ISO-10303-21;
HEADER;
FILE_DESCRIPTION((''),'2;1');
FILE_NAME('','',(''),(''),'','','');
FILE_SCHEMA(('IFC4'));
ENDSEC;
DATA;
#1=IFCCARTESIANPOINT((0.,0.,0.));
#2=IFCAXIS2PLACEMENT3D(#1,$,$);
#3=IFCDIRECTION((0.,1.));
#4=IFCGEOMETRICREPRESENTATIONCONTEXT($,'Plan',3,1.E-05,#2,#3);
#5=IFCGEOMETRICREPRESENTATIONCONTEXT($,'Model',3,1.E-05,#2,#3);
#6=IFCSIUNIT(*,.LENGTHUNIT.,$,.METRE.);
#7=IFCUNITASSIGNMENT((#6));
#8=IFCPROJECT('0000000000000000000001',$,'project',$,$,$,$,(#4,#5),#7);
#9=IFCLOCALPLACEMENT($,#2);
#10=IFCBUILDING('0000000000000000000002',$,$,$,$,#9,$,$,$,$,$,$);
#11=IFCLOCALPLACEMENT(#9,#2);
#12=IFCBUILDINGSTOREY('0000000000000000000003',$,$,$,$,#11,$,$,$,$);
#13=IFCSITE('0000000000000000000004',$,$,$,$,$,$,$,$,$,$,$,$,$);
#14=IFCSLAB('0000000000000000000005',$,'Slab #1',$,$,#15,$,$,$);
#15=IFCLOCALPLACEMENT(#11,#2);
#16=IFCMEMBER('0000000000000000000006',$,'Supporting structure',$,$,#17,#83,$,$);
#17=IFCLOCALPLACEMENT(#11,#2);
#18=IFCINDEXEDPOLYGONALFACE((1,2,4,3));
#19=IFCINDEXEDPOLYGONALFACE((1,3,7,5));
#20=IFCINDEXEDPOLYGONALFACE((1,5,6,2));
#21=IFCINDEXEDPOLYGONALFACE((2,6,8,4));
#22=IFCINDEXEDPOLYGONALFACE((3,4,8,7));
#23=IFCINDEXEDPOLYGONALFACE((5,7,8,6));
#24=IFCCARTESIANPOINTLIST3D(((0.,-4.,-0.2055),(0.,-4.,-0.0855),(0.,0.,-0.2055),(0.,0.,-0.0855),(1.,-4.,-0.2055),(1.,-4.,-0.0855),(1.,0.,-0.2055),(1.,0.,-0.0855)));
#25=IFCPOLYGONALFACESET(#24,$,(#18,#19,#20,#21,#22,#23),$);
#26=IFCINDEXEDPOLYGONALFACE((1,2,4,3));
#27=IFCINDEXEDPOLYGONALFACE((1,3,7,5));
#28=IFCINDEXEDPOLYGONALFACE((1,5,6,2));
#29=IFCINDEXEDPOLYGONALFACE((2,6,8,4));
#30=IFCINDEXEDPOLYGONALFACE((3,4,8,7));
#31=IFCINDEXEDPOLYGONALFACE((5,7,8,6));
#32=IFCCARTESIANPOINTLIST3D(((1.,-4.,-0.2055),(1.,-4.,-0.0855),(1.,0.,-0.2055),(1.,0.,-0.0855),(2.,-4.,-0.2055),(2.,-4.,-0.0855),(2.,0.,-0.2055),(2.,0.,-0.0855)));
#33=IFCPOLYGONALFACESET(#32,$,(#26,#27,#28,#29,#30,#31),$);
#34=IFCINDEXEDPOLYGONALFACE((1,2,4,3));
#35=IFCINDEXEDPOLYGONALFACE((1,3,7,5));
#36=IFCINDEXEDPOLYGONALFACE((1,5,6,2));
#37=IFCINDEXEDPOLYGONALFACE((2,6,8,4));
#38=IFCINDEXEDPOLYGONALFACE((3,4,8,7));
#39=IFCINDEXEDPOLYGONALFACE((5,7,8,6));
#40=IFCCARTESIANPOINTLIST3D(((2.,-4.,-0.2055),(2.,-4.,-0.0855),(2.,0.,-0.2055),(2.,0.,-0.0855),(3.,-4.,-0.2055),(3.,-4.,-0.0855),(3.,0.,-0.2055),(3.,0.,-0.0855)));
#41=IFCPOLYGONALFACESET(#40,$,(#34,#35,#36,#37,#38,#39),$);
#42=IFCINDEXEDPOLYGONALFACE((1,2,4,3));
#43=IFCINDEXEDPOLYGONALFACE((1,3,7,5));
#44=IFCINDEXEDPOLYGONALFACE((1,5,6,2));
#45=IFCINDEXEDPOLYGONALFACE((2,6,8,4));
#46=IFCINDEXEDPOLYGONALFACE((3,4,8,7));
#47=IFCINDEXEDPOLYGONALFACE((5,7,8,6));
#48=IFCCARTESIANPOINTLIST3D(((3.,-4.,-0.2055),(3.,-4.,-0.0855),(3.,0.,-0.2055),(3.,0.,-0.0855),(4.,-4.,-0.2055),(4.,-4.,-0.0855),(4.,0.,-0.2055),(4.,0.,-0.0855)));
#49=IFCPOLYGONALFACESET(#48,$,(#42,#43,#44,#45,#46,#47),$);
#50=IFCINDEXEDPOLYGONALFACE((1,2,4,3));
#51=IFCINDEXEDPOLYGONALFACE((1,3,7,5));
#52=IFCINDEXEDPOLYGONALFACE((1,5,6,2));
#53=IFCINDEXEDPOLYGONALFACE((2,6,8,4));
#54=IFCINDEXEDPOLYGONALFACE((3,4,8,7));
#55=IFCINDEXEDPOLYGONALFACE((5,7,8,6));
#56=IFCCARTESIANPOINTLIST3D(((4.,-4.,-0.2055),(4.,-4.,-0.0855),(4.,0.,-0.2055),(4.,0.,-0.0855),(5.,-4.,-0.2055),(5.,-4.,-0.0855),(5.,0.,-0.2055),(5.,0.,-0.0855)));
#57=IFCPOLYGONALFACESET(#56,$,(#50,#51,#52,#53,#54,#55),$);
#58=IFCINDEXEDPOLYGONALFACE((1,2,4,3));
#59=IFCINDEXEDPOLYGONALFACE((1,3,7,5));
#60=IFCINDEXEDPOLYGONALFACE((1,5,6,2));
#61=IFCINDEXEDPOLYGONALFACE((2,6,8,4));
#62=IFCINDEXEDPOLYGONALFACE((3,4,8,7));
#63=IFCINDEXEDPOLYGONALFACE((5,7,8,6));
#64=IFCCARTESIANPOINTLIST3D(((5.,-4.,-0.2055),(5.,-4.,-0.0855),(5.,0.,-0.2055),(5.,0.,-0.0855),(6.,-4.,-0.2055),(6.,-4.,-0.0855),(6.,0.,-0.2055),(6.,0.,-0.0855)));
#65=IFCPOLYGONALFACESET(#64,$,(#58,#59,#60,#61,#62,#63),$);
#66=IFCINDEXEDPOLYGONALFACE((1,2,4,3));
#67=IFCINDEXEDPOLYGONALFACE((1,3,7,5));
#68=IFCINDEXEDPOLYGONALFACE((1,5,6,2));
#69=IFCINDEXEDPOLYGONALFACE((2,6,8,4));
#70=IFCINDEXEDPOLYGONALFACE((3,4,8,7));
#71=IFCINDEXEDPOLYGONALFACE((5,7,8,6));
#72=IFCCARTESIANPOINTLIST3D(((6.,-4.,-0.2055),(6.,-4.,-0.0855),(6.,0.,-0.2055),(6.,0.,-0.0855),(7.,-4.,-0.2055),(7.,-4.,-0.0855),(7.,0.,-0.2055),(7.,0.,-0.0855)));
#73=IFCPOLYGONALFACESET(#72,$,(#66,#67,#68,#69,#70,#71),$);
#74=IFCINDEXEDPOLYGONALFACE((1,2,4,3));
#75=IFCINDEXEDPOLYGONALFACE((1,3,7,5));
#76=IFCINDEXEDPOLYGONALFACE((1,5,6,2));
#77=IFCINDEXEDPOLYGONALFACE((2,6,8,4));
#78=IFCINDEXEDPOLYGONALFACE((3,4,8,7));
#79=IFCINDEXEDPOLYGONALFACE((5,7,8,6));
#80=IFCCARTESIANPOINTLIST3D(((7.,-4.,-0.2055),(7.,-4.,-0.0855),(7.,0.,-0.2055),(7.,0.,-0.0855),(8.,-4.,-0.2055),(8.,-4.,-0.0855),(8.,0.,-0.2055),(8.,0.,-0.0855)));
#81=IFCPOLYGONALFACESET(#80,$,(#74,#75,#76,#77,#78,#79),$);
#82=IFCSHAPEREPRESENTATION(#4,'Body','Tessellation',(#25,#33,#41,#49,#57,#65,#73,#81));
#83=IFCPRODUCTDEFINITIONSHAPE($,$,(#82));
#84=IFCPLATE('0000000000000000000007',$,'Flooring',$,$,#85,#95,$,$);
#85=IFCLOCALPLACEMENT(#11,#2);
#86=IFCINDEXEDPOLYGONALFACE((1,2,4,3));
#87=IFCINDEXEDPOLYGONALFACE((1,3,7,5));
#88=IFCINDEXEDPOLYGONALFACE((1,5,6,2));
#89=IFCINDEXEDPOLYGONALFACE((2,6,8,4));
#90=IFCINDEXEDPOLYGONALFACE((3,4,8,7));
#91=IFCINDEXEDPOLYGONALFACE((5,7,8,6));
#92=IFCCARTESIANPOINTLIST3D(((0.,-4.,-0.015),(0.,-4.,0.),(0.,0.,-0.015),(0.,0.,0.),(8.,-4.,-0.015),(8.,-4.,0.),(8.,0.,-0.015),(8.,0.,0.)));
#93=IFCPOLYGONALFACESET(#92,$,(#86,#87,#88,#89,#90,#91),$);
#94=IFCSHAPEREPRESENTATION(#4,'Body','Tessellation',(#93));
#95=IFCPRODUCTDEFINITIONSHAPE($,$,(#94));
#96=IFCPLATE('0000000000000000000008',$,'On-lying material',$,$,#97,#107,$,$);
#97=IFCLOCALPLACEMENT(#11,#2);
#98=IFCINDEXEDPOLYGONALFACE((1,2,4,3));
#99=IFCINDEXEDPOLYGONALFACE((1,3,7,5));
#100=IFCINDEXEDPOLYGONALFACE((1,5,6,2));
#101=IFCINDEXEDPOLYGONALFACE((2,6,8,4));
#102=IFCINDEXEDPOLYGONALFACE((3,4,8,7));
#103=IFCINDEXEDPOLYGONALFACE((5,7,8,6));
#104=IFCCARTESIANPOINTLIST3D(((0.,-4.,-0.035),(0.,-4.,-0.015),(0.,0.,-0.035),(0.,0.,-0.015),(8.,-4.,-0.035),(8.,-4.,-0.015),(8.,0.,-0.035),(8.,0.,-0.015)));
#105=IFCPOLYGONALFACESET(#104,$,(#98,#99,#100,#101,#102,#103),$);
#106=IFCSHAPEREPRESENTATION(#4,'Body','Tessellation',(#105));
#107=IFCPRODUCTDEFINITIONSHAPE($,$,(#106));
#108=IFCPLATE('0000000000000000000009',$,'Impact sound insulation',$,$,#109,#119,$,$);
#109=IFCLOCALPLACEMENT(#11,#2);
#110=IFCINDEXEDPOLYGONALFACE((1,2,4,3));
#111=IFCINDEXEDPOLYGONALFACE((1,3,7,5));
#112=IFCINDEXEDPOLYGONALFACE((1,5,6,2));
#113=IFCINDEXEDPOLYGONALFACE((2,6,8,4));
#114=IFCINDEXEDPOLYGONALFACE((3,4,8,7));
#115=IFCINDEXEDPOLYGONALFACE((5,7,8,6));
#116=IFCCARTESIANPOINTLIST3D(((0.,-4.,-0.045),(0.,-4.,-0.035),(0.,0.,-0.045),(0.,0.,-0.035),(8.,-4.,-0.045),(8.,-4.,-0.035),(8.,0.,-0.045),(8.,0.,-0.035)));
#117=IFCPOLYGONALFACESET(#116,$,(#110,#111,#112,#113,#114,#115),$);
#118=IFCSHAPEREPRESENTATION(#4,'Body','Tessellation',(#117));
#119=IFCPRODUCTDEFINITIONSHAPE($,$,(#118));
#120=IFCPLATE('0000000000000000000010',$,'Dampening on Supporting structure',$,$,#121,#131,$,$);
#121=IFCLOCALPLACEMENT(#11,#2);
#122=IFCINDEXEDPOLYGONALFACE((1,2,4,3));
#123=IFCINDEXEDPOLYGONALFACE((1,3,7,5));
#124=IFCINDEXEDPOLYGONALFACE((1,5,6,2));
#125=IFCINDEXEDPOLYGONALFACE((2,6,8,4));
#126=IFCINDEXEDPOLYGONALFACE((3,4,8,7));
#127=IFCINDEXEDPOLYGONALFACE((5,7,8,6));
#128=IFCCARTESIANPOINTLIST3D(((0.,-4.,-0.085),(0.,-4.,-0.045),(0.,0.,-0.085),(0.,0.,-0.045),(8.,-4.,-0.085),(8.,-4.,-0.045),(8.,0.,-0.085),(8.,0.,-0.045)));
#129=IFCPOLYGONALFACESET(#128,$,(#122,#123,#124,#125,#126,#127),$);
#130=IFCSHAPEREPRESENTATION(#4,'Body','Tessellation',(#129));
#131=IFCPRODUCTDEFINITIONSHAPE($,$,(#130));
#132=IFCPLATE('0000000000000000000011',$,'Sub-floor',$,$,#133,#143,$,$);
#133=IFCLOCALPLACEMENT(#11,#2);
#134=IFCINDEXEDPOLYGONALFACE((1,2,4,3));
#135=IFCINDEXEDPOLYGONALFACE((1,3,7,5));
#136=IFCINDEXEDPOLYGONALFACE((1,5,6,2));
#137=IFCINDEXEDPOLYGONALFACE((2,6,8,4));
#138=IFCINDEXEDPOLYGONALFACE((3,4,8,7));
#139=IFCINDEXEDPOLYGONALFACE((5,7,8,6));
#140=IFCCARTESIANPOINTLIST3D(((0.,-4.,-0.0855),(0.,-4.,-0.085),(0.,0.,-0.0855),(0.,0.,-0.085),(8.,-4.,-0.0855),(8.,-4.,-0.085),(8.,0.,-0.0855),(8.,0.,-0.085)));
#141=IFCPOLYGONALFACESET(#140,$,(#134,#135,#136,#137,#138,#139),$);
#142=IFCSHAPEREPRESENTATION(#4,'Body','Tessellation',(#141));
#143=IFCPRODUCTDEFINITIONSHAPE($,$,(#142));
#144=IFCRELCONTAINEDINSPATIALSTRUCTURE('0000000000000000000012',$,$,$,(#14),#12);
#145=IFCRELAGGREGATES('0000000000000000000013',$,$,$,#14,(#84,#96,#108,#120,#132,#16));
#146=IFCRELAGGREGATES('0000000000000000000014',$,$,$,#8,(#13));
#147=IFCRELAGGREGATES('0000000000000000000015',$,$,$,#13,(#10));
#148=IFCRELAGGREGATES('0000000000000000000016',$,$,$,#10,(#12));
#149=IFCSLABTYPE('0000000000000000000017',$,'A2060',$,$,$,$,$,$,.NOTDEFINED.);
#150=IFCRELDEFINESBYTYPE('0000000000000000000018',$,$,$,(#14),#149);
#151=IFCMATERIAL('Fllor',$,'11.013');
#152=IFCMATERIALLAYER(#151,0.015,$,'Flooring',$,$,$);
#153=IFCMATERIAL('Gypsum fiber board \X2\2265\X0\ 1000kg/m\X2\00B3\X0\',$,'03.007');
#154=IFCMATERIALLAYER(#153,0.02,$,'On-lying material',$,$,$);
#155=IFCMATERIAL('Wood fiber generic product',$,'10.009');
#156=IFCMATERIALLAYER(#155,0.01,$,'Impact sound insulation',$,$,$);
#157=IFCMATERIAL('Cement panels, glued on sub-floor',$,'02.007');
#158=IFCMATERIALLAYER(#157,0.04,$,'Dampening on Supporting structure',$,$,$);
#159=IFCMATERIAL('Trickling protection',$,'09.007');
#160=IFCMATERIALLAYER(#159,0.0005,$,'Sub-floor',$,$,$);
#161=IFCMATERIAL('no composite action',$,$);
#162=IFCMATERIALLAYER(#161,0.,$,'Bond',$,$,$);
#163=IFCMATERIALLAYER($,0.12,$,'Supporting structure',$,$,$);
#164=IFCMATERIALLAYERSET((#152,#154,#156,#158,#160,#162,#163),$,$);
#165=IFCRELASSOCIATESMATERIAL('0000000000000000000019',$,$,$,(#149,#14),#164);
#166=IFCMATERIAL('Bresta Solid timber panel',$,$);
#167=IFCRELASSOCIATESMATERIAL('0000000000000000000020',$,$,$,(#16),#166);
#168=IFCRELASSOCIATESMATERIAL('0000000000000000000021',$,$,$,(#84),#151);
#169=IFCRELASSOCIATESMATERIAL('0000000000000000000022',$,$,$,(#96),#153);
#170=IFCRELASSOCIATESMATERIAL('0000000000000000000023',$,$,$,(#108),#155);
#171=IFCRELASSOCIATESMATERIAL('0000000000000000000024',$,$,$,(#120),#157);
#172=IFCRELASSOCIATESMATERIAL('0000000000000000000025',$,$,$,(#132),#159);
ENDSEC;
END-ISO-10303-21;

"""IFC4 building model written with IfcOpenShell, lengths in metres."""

from ifc_helpers import new_model, si_unit, direction, frame, frame_2d, origin, origin_with_axes, place, context, project, spatial, rectangle, extrude, material, layer, layer_set, type_object, element, aggregate, save


model = new_model("IFC4")

# Units and contexts
plan_context = context("Plan", 3, precision=1e-05, world=origin(), true_north=direction((0.0, 1.0)))
model_context = context("Model", 3, precision=1e-05, world=origin(), true_north=direction((0.0, 1.0)))
ifc_project = project(units=[si_unit("LENGTHUNIT", "METRE")], contexts=[plan_context, model_context])

# Site, building, storey
site = spatial("IfcSite", under=ifc_project)
building_placement = place(None, origin())
building = spatial("IfcBuilding", under=site, at=building_placement)
storey_placement = place(building_placement, origin())
storey = spatial("IfcBuildingStorey", under=building, at=storey_placement)

# Slab, member, plates
ifc_material_1 = material(Name="Fllor", Category="11.013")
ifc_layer_1 = layer(ifc_material_1, 0.015, Name="Flooring")
ifc_material_2 = material(Name="Gypsum fiber board ≥ 1000kg/m³", Category="03.007")
ifc_layer_2 = layer(ifc_material_2, 0.02, Name="On-lying material")
ifc_material_3 = material(Name="Wood fiber generic product", Category="10.009")
ifc_layer_3 = layer(ifc_material_3, 0.01, Name="Impact sound insulation")
ifc_material_4 = material(Name="Cement panels, glued on sub-floor", Category="02.007")
ifc_layer_4 = layer(ifc_material_4, 0.04, Name="Dampening on Supporting structure")
ifc_material_5 = material(Name="Trickling protection", Category="09.007")
ifc_layer_5 = layer(ifc_material_5, 0.0005, Name="Sub-floor")
ifc_material_6 = material(Name="no composite action")
ifc_layer_6 = layer(ifc_material_6, 0.0, Name="Bond")
ifc_layer_7 = layer(None, 0.12, Name="Supporting structure")
ifc_layer_set = layer_set([ifc_layer_1, ifc_layer_2, ifc_layer_3, ifc_layer_4, ifc_layer_5, ifc_layer_6, ifc_layer_7])
slab_type = type_object("IfcSlabType", Name="A2060", PredefinedType="NOTDEFINED", material=ifc_layer_set)
slab_placement = place(None, frame((0.0, 0.0, 0.0), z_axis=(0.0, 0.0, -1.0), x_axis=(1.0, 0.0, 0.0)))
slab = element("IfcSlab", 1, at=slab_placement, inside=storey, type_object=slab_type, material=ifc_layer_set, Name="Slab #1")
ifc_material_7 = material(Name="Bresta Solid timber panel")
member_placement = place(slab_placement, origin())
member = element("IfcMember", 2, at=member_placement, material=ifc_material_7, Name="Supporting structure", context=plan_context, shape_type="SweptSolid", body=[
    extrude(rectangle(XDim=1.0, YDim=0.12, at=frame_2d((0.5, 0.06), x_axis=(1.0, 0.0))), frame((0.0, 4.0, 0.0855), z_axis=(0.0, -1.0, 0.0), x_axis=(1.0, 0.0, 0.0)), (0.0, 0.0, 1.0), 4.0),
    extrude(rectangle(XDim=1.0, YDim=0.12, at=frame_2d((0.5, 0.06), x_axis=(1.0, 0.0))), frame((1.0, 4.0, 0.0855), z_axis=(0.0, -1.0, 0.0), x_axis=(1.0, 0.0, 0.0)), (0.0, 0.0, 1.0), 4.0),
    extrude(rectangle(XDim=1.0, YDim=0.12, at=frame_2d((0.5, 0.06), x_axis=(1.0, 0.0))), frame((2.0, 4.0, 0.0855), z_axis=(0.0, -1.0, 0.0), x_axis=(1.0, 0.0, 0.0)), (0.0, 0.0, 1.0), 4.0),
    extrude(rectangle(XDim=1.0, YDim=0.12, at=frame_2d((0.5, 0.06), x_axis=(1.0, 0.0))), frame((3.0, 4.0, 0.0855), z_axis=(0.0, -1.0, 0.0), x_axis=(1.0, 0.0, 0.0)), (0.0, 0.0, 1.0), 4.0),
    extrude(rectangle(XDim=1.0, YDim=0.12, at=frame_2d((0.5, 0.06), x_axis=(1.0, 0.0))), frame((4.0, 4.0, 0.0855), z_axis=(0.0, -1.0, 0.0), x_axis=(1.0, 0.0, 0.0)), (0.0, 0.0, 1.0), 4.0),
    extrude(rectangle(XDim=1.0, YDim=0.12, at=frame_2d((0.5, 0.06), x_axis=(1.0, 0.0))), frame((5.0, 4.0, 0.0855), z_axis=(0.0, -1.0, 0.0), x_axis=(1.0, 0.0, 0.0)), (0.0, 0.0, 1.0), 4.0),
    extrude(rectangle(XDim=1.0, YDim=0.12, at=frame_2d((0.5, 0.06), x_axis=(1.0, 0.0))), frame((6.0, 4.0, 0.0855), z_axis=(0.0, -1.0, 0.0), x_axis=(1.0, 0.0, 0.0)), (0.0, 0.0, 1.0), 4.0),
    extrude(rectangle(XDim=1.0, YDim=0.12, at=frame_2d((0.5, 0.06), x_axis=(1.0, 0.0))), frame((7.0, 4.0, 0.0855), z_axis=(0.0, -1.0, 0.0), x_axis=(1.0, 0.0, 0.0)), (0.0, 0.0, 1.0), 4.0),
])
plate_1_placement = place(slab_placement, origin())
plate_1 = element("IfcPlate", 3, at=plate_1_placement, material=ifc_material_1, Name="Flooring", context=plan_context, shape_type="SweptSolid", body=[
    extrude(rectangle(XDim=8.0, YDim=4.0, at=frame_2d((4.0, 2.0), x_axis=(1.0, 0.0))), origin_with_axes(), (0.0, 0.0, 1.0), 0.015),
])
plate_2_placement = place(slab_placement, origin())
plate_2 = element("IfcPlate", 4, at=plate_2_placement, material=ifc_material_2, Name="On-lying material", context=plan_context, shape_type="SweptSolid", body=[
    extrude(rectangle(XDim=8.0, YDim=4.0, at=frame_2d((4.0, 2.0), x_axis=(1.0, 0.0))), frame((0.0, 0.0, 0.015), z_axis=(0.0, 0.0, 1.0), x_axis=(1.0, 0.0, 0.0)), (0.0, 0.0, 1.0), 0.02),
])
plate_3_placement = place(slab_placement, origin())
plate_3 = element("IfcPlate", 5, at=plate_3_placement, material=ifc_material_3, Name="Impact sound insulation", context=plan_context, shape_type="SweptSolid", body=[
    extrude(rectangle(XDim=8.0, YDim=4.0, at=frame_2d((4.0, 2.0), x_axis=(1.0, 0.0))), frame((0.0, 0.0, 0.035), z_axis=(0.0, 0.0, 1.0), x_axis=(1.0, 0.0, 0.0)), (0.0, 0.0, 1.0), 0.01),
])
plate_4_placement = place(slab_placement, origin())
plate_4 = element("IfcPlate", 6, at=plate_4_placement, material=ifc_material_4, Name="Dampening on Supporting structure", context=plan_context, shape_type="SweptSolid", body=[
    extrude(rectangle(XDim=8.0, YDim=4.0, at=frame_2d((4.0, 2.0), x_axis=(1.0, 0.0))), frame((0.0, 0.0, 0.045), z_axis=(0.0, 0.0, 1.0), x_axis=(1.0, 0.0, 0.0)), (0.0, 0.0, 1.0), 0.04),
])
plate_5_placement = place(slab_placement, origin())
plate_5 = element("IfcPlate", 7, at=plate_5_placement, material=ifc_material_5, Name="Sub-floor", context=plan_context, shape_type="SweptSolid", body=[
    extrude(rectangle(XDim=8.0, YDim=4.0, at=frame_2d((4.0, 2.0), x_axis=(1.0, 0.0))), frame((0.0, 0.0, 0.085), z_axis=(0.0, 0.0, 1.0), x_axis=(1.0, 0.0, 0.0)), (0.0, 0.0, 1.0), 0.0005),
])
aggregate(slab, [plate_1, plate_2, plate_3, plate_4, plate_5, member])

save(model, "model.ifc")
